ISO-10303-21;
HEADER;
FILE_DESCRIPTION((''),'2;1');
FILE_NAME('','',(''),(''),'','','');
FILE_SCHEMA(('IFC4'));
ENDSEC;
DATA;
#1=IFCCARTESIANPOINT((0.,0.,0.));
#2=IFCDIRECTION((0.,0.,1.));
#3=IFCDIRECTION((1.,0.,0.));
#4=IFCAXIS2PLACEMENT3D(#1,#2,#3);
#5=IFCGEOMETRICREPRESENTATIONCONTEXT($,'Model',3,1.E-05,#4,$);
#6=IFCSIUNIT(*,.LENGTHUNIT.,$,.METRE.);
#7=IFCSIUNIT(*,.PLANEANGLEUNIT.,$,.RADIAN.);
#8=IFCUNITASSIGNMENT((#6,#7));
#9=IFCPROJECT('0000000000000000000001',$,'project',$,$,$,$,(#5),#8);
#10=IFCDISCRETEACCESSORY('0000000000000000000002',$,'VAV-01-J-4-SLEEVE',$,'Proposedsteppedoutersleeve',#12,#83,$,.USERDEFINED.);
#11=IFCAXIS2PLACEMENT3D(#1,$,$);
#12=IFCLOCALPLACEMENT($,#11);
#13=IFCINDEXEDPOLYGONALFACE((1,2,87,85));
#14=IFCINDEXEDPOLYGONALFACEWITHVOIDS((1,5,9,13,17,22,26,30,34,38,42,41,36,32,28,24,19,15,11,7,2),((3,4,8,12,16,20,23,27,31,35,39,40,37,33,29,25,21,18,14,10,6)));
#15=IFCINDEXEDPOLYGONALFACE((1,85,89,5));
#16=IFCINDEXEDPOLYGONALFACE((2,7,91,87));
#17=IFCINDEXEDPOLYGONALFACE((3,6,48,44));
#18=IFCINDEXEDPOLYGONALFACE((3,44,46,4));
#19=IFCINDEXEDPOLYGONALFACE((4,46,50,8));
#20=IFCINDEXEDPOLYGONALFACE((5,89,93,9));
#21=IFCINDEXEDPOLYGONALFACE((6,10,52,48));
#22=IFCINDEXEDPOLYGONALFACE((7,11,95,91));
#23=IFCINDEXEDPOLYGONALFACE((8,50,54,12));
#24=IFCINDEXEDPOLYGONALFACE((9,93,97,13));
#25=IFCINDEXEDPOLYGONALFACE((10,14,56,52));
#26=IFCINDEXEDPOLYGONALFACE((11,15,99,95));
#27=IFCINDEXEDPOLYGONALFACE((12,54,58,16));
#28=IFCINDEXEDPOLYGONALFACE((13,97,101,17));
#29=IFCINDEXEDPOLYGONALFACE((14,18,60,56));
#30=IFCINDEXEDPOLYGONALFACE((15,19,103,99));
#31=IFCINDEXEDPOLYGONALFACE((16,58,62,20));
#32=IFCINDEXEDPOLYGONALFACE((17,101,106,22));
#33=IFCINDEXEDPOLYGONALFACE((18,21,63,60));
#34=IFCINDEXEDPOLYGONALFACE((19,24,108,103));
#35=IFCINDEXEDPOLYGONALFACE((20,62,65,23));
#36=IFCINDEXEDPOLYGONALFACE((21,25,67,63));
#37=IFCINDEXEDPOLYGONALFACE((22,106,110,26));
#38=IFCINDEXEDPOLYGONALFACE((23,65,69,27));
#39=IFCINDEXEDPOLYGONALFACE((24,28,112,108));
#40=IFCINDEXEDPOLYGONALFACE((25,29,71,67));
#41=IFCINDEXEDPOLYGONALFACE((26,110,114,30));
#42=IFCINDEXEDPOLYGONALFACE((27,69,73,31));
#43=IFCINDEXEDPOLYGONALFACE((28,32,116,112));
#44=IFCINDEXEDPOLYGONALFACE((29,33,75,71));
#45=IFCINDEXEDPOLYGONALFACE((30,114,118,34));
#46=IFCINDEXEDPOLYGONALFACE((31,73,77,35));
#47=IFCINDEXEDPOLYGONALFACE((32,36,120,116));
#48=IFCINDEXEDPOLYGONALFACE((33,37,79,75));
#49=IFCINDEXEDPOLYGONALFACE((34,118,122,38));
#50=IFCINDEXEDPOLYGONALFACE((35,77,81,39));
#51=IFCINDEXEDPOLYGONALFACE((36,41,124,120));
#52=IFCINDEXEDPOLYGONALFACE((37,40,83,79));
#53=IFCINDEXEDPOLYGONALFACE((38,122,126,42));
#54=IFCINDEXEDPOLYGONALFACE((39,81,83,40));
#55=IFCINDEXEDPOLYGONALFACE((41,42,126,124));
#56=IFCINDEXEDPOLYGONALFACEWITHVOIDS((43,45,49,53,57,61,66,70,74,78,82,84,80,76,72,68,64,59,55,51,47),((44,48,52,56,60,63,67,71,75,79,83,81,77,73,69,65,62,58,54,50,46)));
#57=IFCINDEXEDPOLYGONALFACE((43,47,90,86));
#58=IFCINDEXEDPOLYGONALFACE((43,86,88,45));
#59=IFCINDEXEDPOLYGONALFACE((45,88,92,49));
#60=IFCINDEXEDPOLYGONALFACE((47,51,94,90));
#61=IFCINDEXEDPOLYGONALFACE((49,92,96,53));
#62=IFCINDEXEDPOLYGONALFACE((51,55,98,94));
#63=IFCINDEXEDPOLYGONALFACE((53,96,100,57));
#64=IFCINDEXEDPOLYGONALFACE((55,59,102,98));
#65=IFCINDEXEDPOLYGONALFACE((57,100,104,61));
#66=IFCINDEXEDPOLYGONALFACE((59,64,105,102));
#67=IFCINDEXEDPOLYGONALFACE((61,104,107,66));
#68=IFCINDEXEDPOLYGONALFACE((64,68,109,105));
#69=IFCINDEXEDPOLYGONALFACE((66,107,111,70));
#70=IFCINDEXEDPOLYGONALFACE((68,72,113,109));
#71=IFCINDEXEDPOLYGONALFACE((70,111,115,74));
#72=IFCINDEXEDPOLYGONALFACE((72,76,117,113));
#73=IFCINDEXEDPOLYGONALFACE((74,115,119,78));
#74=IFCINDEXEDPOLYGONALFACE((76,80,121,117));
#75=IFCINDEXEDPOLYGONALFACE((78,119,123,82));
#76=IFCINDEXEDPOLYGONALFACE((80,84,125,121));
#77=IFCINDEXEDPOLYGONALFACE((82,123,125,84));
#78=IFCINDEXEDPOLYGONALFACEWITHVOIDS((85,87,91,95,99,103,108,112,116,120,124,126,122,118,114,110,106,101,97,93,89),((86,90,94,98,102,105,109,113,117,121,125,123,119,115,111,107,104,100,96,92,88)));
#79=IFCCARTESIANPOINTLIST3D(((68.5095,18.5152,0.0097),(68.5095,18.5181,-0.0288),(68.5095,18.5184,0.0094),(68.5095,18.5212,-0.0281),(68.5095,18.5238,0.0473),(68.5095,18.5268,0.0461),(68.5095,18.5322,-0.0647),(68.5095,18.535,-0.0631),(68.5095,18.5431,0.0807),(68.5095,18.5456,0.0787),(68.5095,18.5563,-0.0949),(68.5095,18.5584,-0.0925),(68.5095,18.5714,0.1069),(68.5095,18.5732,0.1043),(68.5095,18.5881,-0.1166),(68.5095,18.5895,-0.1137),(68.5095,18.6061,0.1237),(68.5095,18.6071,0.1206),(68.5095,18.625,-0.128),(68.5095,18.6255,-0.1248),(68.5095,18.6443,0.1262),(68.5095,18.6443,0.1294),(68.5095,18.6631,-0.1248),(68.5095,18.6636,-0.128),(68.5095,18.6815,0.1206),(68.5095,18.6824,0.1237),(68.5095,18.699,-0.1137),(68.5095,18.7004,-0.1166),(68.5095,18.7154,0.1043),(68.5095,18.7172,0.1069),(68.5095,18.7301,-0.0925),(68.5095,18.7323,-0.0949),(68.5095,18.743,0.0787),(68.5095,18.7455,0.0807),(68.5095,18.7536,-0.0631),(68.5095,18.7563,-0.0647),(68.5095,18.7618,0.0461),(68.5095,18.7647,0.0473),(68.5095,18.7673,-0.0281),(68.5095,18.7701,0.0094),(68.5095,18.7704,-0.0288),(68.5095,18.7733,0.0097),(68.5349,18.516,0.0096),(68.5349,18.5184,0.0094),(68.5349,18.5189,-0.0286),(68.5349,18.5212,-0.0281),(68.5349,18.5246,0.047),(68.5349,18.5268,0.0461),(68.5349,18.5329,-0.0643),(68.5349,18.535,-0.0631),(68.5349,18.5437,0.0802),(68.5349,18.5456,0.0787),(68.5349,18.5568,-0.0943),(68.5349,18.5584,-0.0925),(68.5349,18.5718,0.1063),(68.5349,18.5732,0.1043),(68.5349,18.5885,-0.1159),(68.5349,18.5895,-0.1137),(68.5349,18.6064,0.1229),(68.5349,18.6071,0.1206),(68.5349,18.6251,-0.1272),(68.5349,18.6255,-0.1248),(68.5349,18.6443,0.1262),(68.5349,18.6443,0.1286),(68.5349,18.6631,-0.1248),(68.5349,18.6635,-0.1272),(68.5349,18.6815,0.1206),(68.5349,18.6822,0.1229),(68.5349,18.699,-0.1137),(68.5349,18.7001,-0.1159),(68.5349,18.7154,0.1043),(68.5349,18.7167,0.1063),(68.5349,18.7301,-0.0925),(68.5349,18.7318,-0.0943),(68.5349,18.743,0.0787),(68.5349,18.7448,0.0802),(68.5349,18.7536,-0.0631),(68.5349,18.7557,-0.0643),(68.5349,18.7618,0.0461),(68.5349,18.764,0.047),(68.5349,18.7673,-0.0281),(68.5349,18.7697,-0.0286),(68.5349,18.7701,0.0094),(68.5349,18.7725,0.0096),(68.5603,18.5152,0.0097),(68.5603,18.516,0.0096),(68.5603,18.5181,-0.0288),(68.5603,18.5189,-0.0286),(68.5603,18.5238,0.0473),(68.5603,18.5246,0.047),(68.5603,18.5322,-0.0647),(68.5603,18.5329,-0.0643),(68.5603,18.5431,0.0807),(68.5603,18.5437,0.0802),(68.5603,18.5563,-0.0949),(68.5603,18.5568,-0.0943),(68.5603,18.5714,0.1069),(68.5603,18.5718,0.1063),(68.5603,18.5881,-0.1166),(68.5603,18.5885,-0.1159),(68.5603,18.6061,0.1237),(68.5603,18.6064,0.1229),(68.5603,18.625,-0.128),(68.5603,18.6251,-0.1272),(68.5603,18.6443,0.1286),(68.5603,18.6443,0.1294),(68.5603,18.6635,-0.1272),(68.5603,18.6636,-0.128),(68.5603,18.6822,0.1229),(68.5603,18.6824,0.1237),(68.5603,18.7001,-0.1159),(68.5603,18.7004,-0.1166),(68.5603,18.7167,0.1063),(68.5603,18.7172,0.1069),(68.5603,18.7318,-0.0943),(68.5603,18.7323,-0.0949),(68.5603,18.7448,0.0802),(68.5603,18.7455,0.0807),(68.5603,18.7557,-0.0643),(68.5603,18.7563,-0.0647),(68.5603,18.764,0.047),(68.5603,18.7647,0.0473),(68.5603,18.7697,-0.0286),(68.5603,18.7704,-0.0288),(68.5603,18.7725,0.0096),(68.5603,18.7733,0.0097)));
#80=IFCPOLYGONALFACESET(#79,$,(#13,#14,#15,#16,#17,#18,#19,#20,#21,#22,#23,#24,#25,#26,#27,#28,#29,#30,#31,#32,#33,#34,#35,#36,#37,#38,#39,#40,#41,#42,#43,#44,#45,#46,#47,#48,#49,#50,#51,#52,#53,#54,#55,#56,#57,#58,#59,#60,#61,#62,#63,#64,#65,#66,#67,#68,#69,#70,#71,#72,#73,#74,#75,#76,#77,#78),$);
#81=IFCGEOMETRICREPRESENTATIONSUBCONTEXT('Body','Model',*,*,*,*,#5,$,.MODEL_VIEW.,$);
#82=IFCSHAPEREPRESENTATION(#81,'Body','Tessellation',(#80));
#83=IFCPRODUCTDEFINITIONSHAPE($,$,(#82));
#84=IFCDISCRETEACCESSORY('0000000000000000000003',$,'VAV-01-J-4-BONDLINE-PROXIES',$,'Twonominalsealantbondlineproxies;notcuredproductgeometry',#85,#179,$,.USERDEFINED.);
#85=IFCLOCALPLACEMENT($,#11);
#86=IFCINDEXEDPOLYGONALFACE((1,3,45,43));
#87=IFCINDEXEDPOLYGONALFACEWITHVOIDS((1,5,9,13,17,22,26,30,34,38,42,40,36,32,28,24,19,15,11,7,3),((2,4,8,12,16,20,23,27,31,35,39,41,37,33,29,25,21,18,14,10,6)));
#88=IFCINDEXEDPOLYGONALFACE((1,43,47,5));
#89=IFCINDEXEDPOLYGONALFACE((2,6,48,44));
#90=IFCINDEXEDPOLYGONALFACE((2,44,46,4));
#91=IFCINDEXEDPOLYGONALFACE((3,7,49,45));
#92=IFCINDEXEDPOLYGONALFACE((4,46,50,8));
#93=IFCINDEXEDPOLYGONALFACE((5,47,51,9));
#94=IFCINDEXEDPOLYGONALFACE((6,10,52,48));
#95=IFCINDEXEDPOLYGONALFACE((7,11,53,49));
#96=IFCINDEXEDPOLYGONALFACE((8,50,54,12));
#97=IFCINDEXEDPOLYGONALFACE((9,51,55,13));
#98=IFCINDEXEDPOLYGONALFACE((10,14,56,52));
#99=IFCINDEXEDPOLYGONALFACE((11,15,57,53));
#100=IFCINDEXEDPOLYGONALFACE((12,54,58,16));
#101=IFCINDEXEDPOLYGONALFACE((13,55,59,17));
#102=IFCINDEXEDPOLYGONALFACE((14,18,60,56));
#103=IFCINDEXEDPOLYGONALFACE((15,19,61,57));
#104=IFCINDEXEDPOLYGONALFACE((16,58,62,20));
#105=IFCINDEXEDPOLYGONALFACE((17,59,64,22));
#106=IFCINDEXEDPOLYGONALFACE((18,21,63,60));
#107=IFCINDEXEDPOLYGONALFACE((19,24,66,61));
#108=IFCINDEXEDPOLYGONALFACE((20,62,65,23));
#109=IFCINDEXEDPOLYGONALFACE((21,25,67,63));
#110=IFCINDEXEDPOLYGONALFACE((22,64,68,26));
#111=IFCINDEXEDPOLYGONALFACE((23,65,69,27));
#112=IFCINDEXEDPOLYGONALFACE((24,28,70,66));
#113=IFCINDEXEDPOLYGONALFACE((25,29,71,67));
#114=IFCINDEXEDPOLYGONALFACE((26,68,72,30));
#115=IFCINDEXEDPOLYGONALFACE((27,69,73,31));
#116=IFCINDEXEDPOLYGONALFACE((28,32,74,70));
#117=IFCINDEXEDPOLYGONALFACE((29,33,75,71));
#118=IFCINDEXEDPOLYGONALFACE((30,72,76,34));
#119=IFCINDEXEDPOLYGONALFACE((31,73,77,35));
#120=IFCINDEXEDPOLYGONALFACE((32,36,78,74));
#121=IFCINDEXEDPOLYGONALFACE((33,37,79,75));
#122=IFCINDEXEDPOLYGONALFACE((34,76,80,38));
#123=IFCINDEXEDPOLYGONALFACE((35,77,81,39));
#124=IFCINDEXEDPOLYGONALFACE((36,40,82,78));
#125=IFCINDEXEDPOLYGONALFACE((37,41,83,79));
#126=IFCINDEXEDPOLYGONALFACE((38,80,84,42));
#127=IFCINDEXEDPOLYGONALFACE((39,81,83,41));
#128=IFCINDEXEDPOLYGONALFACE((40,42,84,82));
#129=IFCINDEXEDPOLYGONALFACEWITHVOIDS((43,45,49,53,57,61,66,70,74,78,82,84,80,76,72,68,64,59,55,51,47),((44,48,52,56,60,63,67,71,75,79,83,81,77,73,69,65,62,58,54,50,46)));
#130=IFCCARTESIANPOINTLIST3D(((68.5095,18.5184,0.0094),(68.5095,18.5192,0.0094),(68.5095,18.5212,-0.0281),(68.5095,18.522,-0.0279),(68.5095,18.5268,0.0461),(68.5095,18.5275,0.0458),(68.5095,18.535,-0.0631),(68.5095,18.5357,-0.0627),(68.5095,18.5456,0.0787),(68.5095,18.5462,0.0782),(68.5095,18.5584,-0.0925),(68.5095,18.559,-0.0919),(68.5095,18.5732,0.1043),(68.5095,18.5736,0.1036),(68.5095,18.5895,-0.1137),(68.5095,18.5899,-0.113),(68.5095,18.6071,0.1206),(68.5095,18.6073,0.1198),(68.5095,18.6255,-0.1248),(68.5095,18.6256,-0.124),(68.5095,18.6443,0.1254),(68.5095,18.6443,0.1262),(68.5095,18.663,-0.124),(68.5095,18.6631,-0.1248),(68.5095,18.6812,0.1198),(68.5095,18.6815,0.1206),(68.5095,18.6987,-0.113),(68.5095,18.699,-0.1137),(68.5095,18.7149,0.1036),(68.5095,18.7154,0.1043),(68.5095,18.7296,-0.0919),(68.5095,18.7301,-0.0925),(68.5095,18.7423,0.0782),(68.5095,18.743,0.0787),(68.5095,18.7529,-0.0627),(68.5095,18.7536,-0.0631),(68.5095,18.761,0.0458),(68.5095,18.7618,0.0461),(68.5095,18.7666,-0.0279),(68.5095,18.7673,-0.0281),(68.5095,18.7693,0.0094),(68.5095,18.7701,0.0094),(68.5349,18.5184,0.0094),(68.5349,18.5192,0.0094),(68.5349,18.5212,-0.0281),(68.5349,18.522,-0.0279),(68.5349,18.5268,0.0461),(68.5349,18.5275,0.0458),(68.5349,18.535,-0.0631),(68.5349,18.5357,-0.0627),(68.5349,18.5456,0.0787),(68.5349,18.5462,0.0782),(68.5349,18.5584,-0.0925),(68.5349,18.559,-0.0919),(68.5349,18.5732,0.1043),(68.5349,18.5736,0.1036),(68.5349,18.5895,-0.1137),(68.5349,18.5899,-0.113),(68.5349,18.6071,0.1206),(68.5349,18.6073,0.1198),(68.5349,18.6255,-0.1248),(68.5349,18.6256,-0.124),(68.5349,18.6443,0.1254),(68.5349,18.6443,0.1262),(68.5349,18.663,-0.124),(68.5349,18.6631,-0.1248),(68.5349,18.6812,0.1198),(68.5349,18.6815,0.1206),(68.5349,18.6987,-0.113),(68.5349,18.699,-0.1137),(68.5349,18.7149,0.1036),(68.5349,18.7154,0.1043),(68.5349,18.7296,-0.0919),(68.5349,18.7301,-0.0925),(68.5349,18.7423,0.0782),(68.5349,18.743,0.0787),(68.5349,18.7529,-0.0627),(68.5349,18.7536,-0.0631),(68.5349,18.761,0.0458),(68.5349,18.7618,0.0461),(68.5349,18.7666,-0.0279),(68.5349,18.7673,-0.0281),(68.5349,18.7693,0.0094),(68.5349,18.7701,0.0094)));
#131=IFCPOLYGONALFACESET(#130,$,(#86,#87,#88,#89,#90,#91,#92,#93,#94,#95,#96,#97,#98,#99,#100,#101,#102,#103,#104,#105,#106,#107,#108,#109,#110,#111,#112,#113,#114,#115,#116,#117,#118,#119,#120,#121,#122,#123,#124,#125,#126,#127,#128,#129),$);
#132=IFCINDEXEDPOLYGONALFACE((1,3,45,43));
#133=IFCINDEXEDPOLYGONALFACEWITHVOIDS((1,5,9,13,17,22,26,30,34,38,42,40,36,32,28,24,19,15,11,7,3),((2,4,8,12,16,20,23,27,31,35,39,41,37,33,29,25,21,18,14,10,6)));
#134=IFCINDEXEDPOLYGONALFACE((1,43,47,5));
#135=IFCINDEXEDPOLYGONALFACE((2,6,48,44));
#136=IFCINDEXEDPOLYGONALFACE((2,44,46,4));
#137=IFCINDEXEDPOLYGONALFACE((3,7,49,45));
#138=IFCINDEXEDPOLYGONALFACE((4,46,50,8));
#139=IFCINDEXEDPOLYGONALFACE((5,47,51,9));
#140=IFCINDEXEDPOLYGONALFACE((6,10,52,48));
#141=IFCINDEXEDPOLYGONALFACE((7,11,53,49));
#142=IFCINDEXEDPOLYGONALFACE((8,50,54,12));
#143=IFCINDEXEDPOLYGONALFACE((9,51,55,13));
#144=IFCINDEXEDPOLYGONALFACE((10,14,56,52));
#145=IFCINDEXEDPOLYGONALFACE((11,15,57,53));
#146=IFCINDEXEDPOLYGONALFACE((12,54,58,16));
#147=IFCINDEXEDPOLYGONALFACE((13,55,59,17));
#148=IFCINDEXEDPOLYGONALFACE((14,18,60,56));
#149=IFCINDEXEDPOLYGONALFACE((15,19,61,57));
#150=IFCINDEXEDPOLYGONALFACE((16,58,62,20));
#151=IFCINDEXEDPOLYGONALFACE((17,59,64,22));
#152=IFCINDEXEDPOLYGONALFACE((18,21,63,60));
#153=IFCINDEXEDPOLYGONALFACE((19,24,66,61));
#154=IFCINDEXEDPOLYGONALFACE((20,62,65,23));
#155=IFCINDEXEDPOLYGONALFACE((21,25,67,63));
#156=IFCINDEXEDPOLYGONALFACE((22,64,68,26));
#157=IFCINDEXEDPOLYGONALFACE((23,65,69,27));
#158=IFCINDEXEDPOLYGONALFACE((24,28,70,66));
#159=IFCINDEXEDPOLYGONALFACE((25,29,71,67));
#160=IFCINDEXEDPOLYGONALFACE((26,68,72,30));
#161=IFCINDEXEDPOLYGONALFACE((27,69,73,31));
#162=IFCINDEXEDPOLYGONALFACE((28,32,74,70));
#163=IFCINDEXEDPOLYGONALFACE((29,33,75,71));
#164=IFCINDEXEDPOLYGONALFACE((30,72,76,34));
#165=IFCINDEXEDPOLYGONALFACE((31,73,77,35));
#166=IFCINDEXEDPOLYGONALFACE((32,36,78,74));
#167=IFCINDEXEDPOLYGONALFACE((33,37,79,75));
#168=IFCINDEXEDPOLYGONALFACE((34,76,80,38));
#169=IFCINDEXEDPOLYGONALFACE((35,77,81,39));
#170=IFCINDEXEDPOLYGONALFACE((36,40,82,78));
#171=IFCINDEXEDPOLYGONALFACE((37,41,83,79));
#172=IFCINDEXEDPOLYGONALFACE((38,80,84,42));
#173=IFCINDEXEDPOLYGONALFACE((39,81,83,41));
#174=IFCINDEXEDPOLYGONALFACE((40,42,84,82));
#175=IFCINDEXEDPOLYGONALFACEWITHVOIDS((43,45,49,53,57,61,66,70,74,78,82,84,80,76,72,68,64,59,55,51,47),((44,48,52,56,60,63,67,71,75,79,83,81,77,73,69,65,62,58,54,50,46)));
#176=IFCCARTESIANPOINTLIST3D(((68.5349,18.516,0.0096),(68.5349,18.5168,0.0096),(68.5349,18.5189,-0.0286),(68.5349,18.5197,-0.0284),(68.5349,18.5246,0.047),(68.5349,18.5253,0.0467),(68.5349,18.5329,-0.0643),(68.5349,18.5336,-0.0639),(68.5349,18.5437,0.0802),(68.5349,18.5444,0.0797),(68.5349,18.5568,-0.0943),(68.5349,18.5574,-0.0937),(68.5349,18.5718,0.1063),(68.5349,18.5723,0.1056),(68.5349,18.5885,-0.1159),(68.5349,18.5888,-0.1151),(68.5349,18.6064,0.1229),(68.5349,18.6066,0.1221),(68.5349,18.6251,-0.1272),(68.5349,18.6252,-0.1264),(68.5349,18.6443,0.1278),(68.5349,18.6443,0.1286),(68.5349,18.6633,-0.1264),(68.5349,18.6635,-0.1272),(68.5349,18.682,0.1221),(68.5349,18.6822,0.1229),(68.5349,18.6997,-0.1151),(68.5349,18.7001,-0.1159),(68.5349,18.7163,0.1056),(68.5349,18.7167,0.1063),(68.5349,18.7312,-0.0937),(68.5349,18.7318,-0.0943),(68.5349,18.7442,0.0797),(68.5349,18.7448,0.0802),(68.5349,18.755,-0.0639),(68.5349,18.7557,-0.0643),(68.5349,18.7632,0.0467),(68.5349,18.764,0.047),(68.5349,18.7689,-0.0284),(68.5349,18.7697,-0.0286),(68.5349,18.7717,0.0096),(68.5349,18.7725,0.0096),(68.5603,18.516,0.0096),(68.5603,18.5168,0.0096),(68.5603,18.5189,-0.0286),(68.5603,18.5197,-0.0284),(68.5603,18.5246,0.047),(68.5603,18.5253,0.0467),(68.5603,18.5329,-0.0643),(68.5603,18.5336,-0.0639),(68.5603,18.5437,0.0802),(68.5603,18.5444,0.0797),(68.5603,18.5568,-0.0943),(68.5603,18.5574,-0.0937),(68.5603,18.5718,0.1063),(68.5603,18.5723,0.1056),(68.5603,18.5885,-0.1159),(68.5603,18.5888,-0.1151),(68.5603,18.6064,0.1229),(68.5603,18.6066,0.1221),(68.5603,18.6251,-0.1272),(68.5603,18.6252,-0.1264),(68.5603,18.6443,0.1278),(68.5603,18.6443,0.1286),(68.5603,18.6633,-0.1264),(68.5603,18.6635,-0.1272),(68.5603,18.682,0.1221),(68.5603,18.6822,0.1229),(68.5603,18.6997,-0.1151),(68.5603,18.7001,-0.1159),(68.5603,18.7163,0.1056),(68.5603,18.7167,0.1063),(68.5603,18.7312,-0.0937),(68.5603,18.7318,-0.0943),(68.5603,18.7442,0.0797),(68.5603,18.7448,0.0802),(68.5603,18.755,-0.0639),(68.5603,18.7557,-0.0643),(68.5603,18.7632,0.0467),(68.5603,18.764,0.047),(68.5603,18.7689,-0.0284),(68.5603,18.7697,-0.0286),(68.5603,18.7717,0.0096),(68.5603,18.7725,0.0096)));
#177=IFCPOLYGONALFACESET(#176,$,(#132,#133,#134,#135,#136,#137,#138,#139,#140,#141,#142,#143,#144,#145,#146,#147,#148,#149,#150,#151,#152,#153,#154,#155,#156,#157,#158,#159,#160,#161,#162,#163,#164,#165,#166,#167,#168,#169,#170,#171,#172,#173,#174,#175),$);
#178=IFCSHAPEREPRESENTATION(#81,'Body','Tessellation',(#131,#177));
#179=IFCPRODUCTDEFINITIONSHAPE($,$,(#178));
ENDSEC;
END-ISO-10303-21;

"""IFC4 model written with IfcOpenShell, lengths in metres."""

from ifc_helpers import new_model, entity, si_unit, frame, origin_with_axes, place, context, subcontext, project, element, save


model = new_model("IFC4")

# Units and contexts
model_context = context("Model", 3, precision=1e-05, world=origin_with_axes())
body_context = subcontext(model_context, "Body", "Model", "MODEL_VIEW")
ifc_project = project(units=[si_unit("LENGTHUNIT", "METRE"), si_unit("PLANEANGLEUNIT", "RADIAN")], contexts=[model_context])

# Discrete accessories
discrete_accessory_1_placement = place(None, frame((68.5349, 18.6443, 0.0), z_axis=(0.0, 1.0, 0.0), x_axis=(0.0, 0.0, 1.0)))
element("IfcDiscreteAccessory", 1, at=discrete_accessory_1_placement, Name="VAV-01-J-4-SLEEVE", ObjectType="Proposedsteppedoutersleeve", PredefinedType="USERDEFINED", context=body_context, shape_type="SweptSolid", body=[
    entity("IfcRevolvedAreaSolid", entity("IfcArbitraryClosedProfileDef", "AREA", None, entity("IfcPolyline", [entity("IfcCartesianPoint", [0.1262, -0.0254]), entity("IfcCartesianPoint", [0.1294, -0.0254]), entity("IfcCartesianPoint", [0.1294, 0.0254]), entity("IfcCartesianPoint", [0.1286, 0.0254]), entity("IfcCartesianPoint", [0.1286, 0.0]), entity("IfcCartesianPoint", [0.1262, 0.0]), entity("IfcCartesianPoint", [0.1262, -0.0254])])), entity("IfcAxis2Placement3D", entity("IfcCartesianPoint", [0.0, 0.0, 0.0])), entity("IfcAxis1Placement", entity("IfcCartesianPoint", [0.0, 0.0, 0.0]), entity("IfcDirection", [0.0, 1.0, 0.0])), 6.283185),
])
discrete_accessory_2_placement = place(None, frame((68.5349, 18.6443, 0.0), z_axis=(0.0, 1.0, 0.0), x_axis=(0.0, 0.0, 1.0)))
element("IfcDiscreteAccessory", 2, at=discrete_accessory_2_placement, Name="VAV-01-J-4-BONDLINE-PROXIES", ObjectType="Twonominalsealantbondlineproxies;notcuredproductgeometry", PredefinedType="USERDEFINED", context=body_context, shape_type="SweptSolid", body=[
    entity("IfcRevolvedAreaSolid", entity("IfcArbitraryClosedProfileDef", "AREA", None, entity("IfcPolyline", [entity("IfcCartesianPoint", [0.1254, -0.0254]), entity("IfcCartesianPoint", [0.1262, -0.0254]), entity("IfcCartesianPoint", [0.1262, 0.0]), entity("IfcCartesianPoint", [0.1254, 0.0]), entity("IfcCartesianPoint", [0.1254, -0.0254])])), entity("IfcAxis2Placement3D", entity("IfcCartesianPoint", [0.0, 0.0, 0.0])), entity("IfcAxis1Placement", entity("IfcCartesianPoint", [0.0, 0.0, 0.0]), entity("IfcDirection", [0.0, 1.0, 0.0])), 6.283185),
    entity("IfcRevolvedAreaSolid", entity("IfcArbitraryClosedProfileDef", "AREA", None, entity("IfcPolyline", [entity("IfcCartesianPoint", [0.1278, 0.0]), entity("IfcCartesianPoint", [0.1286, 0.0]), entity("IfcCartesianPoint", [0.1286, 0.0254]), entity("IfcCartesianPoint", [0.1278, 0.0254]), entity("IfcCartesianPoint", [0.1278, 0.0])])), entity("IfcAxis2Placement3D", entity("IfcCartesianPoint", [0.0, 0.0, 0.0])), entity("IfcAxis1Placement", entity("IfcCartesianPoint", [0.0, 0.0, 0.0]), entity("IfcDirection", [0.0, 1.0, 0.0])), 6.283185),
])

save(model, "model.ifc")
